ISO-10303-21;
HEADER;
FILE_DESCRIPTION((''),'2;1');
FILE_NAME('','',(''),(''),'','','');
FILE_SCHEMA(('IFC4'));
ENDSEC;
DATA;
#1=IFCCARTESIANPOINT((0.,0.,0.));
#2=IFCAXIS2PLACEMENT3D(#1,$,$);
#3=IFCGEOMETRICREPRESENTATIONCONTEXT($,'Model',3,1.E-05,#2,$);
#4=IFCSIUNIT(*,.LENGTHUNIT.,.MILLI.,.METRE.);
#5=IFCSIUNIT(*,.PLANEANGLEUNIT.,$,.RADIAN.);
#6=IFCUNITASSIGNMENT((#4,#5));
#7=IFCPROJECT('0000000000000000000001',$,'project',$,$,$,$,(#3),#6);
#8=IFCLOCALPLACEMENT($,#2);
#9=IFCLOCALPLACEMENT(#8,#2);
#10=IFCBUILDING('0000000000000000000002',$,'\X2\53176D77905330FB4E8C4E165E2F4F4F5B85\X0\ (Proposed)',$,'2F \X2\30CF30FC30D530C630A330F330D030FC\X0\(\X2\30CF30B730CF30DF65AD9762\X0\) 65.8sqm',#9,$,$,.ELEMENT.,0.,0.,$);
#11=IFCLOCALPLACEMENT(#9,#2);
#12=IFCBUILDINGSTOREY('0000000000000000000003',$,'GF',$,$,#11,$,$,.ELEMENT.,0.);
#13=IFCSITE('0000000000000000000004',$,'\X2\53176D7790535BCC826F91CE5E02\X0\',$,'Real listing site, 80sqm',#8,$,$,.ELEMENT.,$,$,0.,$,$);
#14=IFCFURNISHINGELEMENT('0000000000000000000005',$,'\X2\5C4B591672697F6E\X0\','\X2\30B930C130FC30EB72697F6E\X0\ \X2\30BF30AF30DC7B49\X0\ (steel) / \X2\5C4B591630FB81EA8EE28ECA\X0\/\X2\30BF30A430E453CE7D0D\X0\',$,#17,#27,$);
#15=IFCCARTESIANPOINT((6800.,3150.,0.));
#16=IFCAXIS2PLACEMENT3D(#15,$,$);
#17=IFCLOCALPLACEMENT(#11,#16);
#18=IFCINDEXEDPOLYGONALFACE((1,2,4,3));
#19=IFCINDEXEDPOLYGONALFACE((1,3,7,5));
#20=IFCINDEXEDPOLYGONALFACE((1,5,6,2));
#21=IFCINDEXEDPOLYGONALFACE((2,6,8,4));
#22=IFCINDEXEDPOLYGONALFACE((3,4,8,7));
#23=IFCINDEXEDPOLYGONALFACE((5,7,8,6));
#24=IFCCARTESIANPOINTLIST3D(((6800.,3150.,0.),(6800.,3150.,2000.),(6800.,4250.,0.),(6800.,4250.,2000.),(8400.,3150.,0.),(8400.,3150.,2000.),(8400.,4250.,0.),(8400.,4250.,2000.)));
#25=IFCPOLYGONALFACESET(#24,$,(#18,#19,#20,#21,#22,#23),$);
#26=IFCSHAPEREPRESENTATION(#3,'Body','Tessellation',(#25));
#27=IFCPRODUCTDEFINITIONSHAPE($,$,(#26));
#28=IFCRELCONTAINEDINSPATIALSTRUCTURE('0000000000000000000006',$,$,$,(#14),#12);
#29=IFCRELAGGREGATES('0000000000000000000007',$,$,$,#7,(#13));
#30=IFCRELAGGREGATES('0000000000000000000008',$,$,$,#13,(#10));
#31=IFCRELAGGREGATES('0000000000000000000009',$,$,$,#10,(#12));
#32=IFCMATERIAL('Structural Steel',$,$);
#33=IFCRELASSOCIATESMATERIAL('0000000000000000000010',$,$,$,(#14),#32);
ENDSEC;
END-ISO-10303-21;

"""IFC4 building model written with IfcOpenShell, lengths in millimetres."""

from ifc_helpers import new_model, si_unit, frame, frame_2d, origin, place, context, project, spatial, rectangle, extrude, material, element, save


model = new_model("IFC4")

# Units and contexts
model_context = context("Model", 3, precision=1e-05, world=origin())
ifc_project = project(units=[si_unit("LENGTHUNIT", "METRE", prefix="MILLI"), si_unit("PLANEANGLEUNIT", "RADIAN")], contexts=[model_context])

# Site, building, storey
site_placement = place(None, origin())
site = spatial("IfcSite", under=ifc_project, at=site_placement, Name="北海道富良野市", ObjectType="Real listing site, 80sqm", CompositionType="ELEMENT", RefElevation=0.0)
building_placement = place(site_placement, origin())
building = spatial("IfcBuilding", under=site, at=building_placement, Name="北海道・二世帯住宅 (Proposed)", ObjectType="2F ハーフティンバー(ハシハミ断面) 65.8sqm", CompositionType="ELEMENT", ElevationOfRefHeight=0.0, ElevationOfTerrain=0.0)
storey_placement = place(building_placement, origin())
storey = spatial("IfcBuildingStorey", under=building, at=storey_placement, Name="GF", CompositionType="ELEMENT", Elevation=0.0)

# Shared definitions
ifc_material_1 = material(Name="Structural Steel")

# Furnishing element
furnishing_1_placement = place(storey_placement, frame((6800.0, 3150.0, 0.0)))
element("IfcFurnishingElement", 1, at=furnishing_1_placement, inside=storey, material=ifc_material_1, Name="屋外物置", Description="スチール物置 タクボ等 (steel) / 屋外・自転車/タイヤ収納", context=model_context, shape_type="SweptSolid", body=[
    extrude(rectangle(XDim=1600.0, YDim=1100.0, at=frame_2d((800.0, 550.0))), frame((6800.0, 3150.0, 0.0)), (0.0, 0.0, 1.0), 2000.0),
])

save(model, "model.ifc")
